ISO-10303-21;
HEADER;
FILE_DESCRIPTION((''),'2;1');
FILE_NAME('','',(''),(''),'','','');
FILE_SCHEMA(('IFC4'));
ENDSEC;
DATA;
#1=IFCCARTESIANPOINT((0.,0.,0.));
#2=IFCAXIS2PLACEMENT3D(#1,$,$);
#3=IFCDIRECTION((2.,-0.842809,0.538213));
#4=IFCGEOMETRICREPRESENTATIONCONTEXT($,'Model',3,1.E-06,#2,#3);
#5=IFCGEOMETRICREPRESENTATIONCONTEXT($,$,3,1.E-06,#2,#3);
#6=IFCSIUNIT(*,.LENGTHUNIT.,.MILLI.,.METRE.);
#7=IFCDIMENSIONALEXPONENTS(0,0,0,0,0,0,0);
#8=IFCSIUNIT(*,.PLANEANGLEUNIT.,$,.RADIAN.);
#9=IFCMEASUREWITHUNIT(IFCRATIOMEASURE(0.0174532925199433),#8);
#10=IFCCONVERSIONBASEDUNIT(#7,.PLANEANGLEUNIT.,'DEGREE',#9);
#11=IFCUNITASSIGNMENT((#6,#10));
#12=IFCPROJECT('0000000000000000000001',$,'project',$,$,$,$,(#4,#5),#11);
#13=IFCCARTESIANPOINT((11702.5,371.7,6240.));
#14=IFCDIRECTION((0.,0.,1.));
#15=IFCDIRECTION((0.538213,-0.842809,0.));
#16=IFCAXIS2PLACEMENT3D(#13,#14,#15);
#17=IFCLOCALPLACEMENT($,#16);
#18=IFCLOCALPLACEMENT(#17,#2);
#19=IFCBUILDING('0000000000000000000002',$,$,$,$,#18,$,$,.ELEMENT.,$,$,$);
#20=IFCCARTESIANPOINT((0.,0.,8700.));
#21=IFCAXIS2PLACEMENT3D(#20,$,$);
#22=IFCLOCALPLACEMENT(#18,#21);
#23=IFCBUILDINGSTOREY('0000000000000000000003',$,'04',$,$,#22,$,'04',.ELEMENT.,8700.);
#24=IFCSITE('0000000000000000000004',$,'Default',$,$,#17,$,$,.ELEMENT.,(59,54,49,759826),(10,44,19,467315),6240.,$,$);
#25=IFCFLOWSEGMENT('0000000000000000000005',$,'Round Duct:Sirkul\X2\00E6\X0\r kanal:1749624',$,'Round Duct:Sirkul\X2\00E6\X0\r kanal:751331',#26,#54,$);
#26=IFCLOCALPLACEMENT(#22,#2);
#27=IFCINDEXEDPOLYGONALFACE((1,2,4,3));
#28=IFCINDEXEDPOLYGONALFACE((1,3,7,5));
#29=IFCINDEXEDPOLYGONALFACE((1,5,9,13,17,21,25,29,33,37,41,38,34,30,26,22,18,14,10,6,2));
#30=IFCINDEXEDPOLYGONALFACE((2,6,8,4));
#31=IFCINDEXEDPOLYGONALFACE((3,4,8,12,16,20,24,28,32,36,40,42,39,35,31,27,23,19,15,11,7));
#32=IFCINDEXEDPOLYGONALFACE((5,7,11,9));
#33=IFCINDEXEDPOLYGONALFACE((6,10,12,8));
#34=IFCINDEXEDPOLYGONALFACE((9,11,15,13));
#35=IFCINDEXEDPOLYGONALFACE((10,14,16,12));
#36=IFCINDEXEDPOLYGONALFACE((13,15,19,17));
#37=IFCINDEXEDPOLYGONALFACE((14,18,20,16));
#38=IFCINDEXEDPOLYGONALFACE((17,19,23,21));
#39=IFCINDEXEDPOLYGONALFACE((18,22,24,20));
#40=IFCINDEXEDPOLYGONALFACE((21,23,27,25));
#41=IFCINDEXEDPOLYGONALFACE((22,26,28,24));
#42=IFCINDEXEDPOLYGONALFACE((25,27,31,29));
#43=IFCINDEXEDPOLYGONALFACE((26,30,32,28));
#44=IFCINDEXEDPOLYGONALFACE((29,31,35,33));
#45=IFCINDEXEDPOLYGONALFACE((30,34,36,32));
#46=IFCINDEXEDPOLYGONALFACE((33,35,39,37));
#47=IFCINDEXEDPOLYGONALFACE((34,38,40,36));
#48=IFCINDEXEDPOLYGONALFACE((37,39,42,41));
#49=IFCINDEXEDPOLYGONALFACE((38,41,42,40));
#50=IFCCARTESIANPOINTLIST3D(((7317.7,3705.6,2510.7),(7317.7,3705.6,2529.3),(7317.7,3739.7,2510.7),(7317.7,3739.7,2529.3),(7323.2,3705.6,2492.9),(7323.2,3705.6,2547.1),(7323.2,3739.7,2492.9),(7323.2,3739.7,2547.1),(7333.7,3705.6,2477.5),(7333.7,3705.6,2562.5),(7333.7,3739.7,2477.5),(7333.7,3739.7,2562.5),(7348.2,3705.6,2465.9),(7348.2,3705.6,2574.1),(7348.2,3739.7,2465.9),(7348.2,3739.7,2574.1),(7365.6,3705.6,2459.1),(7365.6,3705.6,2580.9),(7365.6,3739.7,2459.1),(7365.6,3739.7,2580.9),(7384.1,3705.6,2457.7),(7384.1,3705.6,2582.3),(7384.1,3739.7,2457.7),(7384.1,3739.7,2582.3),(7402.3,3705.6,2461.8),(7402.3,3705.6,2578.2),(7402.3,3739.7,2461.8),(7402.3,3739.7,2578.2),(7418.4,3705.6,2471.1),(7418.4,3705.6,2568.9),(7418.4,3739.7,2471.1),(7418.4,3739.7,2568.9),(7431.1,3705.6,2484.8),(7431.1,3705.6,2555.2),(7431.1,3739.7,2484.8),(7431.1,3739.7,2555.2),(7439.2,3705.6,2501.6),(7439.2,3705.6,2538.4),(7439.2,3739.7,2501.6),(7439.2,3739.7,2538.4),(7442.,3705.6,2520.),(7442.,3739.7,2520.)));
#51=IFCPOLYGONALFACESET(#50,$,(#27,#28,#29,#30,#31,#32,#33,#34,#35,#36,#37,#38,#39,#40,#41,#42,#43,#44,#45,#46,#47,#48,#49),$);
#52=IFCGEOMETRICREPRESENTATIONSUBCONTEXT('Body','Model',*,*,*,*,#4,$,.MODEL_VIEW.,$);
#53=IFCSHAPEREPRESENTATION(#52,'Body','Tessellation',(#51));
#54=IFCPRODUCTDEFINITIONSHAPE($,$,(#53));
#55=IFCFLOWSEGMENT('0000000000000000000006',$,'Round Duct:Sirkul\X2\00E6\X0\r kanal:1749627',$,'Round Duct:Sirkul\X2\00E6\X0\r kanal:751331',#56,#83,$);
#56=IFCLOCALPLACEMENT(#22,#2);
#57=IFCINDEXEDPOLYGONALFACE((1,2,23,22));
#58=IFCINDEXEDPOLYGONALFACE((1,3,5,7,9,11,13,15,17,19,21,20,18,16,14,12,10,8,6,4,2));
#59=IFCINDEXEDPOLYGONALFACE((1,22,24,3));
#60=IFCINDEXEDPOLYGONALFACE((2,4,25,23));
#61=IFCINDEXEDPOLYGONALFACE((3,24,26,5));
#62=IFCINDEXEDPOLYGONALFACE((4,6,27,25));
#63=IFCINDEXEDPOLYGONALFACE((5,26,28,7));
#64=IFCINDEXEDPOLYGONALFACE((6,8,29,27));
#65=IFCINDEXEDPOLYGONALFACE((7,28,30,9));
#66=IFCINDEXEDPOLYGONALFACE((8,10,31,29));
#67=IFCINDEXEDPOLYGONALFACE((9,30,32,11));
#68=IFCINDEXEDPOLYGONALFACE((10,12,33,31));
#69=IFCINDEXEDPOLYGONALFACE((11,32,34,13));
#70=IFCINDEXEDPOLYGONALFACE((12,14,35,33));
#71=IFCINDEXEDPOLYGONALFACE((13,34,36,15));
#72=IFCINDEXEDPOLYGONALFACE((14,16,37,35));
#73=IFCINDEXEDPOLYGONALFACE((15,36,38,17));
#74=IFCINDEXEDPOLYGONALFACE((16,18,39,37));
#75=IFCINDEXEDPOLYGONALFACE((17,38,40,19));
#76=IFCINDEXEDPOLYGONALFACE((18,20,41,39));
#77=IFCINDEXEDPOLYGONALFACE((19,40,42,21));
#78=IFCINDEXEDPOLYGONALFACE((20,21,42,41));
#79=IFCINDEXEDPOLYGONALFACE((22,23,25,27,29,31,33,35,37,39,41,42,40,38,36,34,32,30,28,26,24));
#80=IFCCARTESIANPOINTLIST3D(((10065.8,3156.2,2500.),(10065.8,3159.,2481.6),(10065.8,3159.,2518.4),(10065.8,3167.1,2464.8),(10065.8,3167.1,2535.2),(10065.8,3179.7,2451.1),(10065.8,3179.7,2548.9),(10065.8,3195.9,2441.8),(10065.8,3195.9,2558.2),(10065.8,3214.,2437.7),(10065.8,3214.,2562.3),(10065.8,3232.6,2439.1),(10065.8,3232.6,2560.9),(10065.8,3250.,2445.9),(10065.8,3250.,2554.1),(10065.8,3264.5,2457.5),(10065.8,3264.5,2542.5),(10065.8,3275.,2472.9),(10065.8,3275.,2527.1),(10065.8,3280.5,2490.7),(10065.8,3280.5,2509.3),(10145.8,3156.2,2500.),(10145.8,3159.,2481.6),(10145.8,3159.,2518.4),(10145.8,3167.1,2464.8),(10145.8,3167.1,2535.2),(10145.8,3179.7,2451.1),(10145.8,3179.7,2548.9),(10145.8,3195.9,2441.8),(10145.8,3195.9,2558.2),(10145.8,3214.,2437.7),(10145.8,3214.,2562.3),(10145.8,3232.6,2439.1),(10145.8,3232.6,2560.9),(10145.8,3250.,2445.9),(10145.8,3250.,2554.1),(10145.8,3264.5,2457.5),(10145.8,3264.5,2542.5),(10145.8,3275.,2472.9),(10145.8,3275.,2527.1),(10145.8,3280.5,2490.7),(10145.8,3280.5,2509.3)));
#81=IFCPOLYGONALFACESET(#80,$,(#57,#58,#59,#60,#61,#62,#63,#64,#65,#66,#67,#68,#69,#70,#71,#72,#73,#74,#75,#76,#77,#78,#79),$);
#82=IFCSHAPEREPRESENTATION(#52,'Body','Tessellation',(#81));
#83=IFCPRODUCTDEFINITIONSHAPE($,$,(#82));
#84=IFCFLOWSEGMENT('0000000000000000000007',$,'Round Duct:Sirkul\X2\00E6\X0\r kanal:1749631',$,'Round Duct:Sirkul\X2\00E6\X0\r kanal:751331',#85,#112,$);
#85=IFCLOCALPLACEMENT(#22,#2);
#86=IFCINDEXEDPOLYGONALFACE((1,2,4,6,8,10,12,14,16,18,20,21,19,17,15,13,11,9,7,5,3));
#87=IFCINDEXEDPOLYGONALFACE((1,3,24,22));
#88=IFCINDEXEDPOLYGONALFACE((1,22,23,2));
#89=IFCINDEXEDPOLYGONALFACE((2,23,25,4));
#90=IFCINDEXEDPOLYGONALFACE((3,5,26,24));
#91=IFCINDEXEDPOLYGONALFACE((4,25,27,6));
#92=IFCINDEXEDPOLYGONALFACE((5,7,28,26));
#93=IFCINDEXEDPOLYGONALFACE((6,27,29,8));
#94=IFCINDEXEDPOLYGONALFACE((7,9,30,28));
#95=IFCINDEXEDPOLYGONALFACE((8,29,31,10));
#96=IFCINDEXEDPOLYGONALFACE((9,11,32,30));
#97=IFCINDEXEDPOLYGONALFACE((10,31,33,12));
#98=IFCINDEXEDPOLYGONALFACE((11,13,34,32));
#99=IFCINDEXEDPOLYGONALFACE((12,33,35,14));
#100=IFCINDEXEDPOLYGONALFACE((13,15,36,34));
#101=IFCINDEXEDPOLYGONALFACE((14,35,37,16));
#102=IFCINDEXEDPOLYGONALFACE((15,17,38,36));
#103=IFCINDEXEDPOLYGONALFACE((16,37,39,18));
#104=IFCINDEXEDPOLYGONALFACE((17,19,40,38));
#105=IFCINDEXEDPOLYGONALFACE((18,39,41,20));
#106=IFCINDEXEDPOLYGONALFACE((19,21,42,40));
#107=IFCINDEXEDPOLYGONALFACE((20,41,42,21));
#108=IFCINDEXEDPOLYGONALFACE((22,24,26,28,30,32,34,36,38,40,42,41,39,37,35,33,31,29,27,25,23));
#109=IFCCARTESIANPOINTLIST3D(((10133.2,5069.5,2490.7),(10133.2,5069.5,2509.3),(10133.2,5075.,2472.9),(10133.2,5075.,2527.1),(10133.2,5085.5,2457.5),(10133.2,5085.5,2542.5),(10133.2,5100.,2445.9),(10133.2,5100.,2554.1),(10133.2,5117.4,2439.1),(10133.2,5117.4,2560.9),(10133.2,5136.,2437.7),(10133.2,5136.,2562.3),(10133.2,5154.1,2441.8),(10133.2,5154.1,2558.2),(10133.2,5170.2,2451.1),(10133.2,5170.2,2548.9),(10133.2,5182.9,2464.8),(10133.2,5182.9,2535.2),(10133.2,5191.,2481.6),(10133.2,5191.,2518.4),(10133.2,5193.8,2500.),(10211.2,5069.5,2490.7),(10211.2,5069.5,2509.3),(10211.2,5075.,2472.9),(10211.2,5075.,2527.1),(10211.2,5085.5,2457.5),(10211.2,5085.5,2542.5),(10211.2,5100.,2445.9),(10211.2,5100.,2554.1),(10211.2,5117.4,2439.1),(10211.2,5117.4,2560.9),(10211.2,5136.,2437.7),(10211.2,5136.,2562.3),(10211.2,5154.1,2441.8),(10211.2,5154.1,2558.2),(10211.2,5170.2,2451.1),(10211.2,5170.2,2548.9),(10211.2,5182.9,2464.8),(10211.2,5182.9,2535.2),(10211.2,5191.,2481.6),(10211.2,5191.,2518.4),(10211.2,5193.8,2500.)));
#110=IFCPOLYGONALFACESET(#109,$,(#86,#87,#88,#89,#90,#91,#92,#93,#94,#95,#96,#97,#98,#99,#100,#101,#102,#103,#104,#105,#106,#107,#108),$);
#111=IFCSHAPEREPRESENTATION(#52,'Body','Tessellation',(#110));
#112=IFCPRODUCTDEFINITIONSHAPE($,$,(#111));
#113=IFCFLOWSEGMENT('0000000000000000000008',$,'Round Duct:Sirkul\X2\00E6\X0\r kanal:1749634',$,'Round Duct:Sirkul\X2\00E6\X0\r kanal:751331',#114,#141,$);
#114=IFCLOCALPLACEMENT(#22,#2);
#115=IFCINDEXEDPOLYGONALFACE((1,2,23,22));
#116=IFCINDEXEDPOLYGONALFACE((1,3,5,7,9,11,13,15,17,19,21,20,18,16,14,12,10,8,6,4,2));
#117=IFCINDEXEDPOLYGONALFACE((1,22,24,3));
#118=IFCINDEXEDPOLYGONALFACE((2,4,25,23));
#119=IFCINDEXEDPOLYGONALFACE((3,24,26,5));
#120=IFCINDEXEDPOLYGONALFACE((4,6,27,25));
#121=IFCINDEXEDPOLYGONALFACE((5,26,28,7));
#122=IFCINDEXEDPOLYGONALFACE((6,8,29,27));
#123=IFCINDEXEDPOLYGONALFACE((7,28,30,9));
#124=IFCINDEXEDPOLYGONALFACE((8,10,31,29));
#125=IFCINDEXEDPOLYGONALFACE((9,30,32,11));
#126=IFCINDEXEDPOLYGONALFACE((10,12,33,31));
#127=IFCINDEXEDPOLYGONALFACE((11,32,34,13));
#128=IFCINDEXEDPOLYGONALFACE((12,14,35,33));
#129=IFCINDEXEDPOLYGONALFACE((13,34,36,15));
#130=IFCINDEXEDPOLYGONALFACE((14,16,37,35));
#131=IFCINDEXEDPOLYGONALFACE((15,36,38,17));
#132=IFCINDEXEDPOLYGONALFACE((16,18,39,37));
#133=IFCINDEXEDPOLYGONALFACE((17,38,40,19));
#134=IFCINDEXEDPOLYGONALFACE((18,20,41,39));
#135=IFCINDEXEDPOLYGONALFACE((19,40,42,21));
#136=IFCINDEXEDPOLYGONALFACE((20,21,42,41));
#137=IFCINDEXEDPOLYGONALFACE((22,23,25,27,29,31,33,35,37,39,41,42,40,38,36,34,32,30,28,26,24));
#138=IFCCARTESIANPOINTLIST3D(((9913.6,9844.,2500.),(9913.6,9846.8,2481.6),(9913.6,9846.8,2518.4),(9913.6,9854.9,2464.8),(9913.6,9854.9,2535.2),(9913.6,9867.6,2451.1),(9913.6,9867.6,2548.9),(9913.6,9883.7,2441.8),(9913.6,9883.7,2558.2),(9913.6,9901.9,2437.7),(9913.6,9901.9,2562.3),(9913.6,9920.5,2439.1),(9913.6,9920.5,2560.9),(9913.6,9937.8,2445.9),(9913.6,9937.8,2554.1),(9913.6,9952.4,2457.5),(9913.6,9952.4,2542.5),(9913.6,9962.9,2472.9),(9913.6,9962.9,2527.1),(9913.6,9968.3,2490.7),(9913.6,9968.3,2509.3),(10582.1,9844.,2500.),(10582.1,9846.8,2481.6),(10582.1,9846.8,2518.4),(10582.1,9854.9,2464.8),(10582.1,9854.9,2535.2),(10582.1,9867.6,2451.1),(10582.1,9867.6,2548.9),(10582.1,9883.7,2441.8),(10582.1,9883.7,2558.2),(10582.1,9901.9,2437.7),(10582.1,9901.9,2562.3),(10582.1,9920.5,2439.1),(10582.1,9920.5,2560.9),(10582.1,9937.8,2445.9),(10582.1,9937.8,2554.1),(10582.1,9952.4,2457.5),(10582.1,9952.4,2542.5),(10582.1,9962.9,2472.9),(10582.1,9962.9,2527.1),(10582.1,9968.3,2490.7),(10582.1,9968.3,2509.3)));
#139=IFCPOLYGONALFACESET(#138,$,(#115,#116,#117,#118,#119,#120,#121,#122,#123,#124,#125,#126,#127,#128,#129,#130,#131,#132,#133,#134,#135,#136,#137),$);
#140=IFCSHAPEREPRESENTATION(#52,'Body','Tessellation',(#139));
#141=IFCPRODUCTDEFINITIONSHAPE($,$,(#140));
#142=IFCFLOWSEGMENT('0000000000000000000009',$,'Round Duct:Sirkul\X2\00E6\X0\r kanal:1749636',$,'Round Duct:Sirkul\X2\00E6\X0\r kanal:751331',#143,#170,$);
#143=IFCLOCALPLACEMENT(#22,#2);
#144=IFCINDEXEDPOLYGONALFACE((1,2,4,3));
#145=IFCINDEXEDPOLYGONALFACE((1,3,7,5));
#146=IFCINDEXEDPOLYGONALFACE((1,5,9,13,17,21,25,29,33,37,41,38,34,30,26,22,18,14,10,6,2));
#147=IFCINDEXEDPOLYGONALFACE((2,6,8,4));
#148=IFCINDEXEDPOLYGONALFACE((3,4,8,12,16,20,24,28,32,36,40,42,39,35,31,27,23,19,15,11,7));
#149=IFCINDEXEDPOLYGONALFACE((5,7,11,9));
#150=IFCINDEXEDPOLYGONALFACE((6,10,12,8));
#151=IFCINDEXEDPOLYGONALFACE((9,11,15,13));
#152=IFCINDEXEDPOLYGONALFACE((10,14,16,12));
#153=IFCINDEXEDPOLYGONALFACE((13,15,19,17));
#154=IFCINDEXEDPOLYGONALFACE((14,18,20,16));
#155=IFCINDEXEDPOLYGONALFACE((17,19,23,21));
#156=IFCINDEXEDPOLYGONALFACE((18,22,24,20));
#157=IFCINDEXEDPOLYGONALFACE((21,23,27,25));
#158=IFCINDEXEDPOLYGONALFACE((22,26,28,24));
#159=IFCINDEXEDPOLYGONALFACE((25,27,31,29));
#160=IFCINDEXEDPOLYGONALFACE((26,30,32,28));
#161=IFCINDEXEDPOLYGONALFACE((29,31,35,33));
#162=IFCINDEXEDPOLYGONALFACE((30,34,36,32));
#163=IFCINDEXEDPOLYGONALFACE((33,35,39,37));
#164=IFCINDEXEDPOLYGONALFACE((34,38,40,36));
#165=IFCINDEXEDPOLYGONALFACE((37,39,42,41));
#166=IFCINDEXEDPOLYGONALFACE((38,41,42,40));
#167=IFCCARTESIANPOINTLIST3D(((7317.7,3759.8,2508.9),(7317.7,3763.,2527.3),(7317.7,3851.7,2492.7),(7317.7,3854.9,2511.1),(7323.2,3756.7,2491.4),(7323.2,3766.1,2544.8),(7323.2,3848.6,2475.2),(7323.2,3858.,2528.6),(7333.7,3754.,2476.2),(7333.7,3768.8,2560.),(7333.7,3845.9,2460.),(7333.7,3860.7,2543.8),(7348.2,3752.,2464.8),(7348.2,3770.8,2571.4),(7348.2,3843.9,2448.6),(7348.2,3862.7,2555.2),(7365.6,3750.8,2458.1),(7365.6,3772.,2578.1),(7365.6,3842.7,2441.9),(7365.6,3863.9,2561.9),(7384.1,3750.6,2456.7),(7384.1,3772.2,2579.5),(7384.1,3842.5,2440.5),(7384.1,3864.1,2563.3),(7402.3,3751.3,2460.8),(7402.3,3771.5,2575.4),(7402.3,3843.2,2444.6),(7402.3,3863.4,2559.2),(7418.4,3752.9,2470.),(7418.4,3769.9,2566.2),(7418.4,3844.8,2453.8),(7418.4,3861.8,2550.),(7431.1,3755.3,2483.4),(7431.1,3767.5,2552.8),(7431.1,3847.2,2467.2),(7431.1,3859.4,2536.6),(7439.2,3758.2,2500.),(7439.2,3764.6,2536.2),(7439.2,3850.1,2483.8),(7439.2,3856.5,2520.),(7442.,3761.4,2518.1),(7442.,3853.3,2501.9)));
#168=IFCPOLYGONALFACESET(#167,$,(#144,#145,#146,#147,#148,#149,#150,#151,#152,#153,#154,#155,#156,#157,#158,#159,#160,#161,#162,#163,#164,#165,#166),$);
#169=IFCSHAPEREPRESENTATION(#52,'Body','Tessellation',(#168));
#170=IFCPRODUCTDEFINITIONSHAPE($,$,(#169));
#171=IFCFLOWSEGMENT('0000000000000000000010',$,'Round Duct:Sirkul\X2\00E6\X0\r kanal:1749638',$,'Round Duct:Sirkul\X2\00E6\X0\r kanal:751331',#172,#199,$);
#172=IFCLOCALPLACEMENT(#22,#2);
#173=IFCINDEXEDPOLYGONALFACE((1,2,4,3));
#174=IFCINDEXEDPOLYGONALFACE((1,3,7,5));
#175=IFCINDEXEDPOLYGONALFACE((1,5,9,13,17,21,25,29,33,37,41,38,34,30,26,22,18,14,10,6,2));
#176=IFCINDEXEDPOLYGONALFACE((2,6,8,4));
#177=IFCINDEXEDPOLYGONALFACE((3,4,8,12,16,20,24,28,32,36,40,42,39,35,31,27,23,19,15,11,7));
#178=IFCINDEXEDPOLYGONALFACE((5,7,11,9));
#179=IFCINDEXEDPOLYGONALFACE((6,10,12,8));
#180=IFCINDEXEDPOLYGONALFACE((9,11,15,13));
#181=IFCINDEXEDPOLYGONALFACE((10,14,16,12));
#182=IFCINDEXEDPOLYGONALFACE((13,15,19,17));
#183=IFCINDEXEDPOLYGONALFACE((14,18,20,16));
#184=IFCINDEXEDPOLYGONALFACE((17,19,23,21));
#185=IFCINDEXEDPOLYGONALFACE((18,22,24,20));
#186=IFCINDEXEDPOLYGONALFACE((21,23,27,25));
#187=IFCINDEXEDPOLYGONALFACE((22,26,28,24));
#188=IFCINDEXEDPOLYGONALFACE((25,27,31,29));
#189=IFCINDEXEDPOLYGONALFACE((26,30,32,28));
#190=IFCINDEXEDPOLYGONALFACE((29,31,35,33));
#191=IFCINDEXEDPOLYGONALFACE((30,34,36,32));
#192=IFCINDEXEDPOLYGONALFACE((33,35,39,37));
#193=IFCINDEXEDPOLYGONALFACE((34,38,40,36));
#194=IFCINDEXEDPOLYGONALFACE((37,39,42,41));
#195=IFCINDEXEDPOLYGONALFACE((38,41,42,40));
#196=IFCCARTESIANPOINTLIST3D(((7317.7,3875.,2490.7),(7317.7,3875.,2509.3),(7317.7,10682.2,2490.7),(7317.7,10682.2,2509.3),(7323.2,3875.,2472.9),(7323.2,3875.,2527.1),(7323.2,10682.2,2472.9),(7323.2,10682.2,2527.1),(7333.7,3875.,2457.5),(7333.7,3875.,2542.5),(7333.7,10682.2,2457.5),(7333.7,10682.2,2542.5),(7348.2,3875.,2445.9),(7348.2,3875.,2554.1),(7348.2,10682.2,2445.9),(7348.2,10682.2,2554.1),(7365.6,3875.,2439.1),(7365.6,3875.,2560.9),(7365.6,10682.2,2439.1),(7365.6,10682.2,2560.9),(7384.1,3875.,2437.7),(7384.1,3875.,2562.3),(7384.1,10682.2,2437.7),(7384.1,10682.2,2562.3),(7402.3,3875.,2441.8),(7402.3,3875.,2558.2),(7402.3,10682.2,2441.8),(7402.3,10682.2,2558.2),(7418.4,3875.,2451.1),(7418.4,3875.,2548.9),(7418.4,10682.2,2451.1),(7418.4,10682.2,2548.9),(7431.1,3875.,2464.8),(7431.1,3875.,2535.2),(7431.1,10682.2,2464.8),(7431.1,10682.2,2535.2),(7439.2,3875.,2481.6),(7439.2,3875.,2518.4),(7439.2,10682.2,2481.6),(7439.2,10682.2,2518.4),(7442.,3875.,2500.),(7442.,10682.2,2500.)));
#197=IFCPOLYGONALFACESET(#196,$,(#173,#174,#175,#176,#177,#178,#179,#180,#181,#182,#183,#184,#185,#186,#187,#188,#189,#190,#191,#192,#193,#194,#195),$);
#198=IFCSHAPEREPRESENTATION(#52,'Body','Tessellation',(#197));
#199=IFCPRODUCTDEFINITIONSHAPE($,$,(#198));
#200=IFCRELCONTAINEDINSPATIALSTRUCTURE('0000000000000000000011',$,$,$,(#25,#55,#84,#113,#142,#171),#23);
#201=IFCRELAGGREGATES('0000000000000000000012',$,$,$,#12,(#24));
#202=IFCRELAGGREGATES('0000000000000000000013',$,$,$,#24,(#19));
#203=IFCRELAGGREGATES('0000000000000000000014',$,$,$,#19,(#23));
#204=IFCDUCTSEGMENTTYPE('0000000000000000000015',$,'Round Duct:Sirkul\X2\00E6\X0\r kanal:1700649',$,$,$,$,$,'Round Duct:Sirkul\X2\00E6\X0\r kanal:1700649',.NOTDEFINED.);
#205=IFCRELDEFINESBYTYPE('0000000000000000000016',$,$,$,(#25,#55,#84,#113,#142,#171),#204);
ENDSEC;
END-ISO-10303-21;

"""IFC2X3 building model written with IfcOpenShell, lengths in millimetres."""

from ifc_helpers import new_model, entity, si_unit, converted_unit, direction, frame, frame_2d, origin, origin_2d_with_axis, place, context, subcontext, project, spatial, circle, extrude, type_object, element, save


model = new_model("IFC2X3")

# Units and contexts
model_context = context("Model", 3, precision=1e-06, world=origin(), true_north=direction((2.0, -0.842809, 0.538213)))
context_of_model = context(None, 3, precision=1e-06, world=origin(), true_north=direction((2.0, -0.842809, 0.538213)))
body_context = subcontext(model_context, "Body", "Model", "MODEL_VIEW")
ifc_project = project(units=[si_unit("LENGTHUNIT", "METRE", prefix="MILLI"), converted_unit("PLANEANGLEUNIT", "DEGREE", entity("IfcRatioMeasure", 0.0174532925199433), si_unit("PLANEANGLEUNIT", "RADIAN"), dimensions=[0, 0, 0, 0, 0, 0, 0])], contexts=[model_context, context_of_model])

# Site, building, storey
site_placement = place(None, frame((11702.5, 371.7, 6240.0), z_axis=(0.0, 0.0, 1.0), x_axis=(0.538213, -0.842809, 0.0)))
site = spatial("IfcSite", under=ifc_project, at=site_placement, Name="Default", CompositionType="ELEMENT", RefLatitude=(59, 54, 49, 759826), RefLongitude=(10, 44, 19, 467315), RefElevation=6240.0)
building_placement = place(site_placement, origin())
building = spatial("IfcBuilding", under=site, at=building_placement, CompositionType="ELEMENT")
storey_placement = place(building_placement, frame((0.0, 0.0, 8700.0)))
storey = spatial("IfcBuildingStorey", under=building, at=storey_placement, Name="04", LongName="04", CompositionType="ELEMENT", Elevation=8700.0)

# Flow segments
duct_segment_type = type_object("IfcDuctSegmentType", Name="Round Duct:Sirkulær kanal:1700649", ElementType="Round Duct:Sirkulær kanal:1700649", PredefinedType="NOTDEFINED")
flow_segment_1_placement = place(storey_placement, origin())
element("IfcFlowSegment", 1, at=flow_segment_1_placement, inside=storey, type_object=duct_segment_type, Name="Round Duct:Sirkulær kanal:1749624", ObjectType="Round Duct:Sirkulær kanal:751331", context=body_context, shape_type="SweptSolid", body=[
    extrude(circle(Radius=62.5, at=origin_2d_with_axis()), frame((7379.5, 3705.6, 2520.0), z_axis=(0.0, 1.0, 0.0), x_axis=(1.0, 0.0, 0.0)), (0.0, 0.0, 1.0), 34.1),
])
flow_segment_2_placement = place(storey_placement, origin())
element("IfcFlowSegment", 2, at=flow_segment_2_placement, inside=storey, type_object=duct_segment_type, Name="Round Duct:Sirkulær kanal:1749627", ObjectType="Round Duct:Sirkulær kanal:751331", context=body_context, shape_type="SweptSolid", body=[
    extrude(circle(Radius=62.5, at=frame_2d((0.0, 0.0), x_axis=(1.0, 0.0))), frame((10065.8, 3218.7, 2500.0), z_axis=(1.0, 0.0, 0.0), x_axis=(0.0, -1.0, 0.0)), (0.0, 0.0, 1.0), 80.0),
])
flow_segment_3_placement = place(storey_placement, origin())
element("IfcFlowSegment", 3, at=flow_segment_3_placement, inside=storey, type_object=duct_segment_type, Name="Round Duct:Sirkulær kanal:1749631", ObjectType="Round Duct:Sirkulær kanal:751331", context=body_context, shape_type="SweptSolid", body=[
    extrude(circle(Radius=62.5, at=origin_2d_with_axis()), frame((10133.2, 5131.3, 2500.0), z_axis=(1.0, 0.0, 0.0), x_axis=(0.0, 1.0, 0.0)), (0.0, 0.0, 1.0), 78.0),
])
flow_segment_4_placement = place(storey_placement, origin())
element("IfcFlowSegment", 4, at=flow_segment_4_placement, inside=storey, type_object=duct_segment_type, Name="Round Duct:Sirkulær kanal:1749634", ObjectType="Round Duct:Sirkulær kanal:751331", context=body_context, shape_type="SweptSolid", body=[
    extrude(circle(Radius=62.5, at=origin_2d_with_axis()), frame((9913.6, 9906.5, 2500.0), z_axis=(1.0, 0.0, 0.0), x_axis=(0.0, -1.0, 0.0)), (0.0, 0.0, 1.0), 668.5),
])
flow_segment_5_placement = place(storey_placement, origin())
element("IfcFlowSegment", 5, at=flow_segment_5_placement, inside=storey, type_object=duct_segment_type, Name="Round Duct:Sirkulær kanal:1749636", ObjectType="Round Duct:Sirkulær kanal:751331", context=body_context, shape_type="SweptSolid", body=[
    extrude(circle(Radius=62.5, at=origin_2d_with_axis()), frame((7379.5, 3761.4, 2518.1), z_axis=(0.0, 0.984808, -0.173648), x_axis=(1.0, 0.0, 0.0)), (0.0, 0.0, 1.0), 93.3),
])
flow_segment_6_placement = place(storey_placement, origin())
element("IfcFlowSegment", 6, at=flow_segment_6_placement, inside=storey, type_object=duct_segment_type, Name="Round Duct:Sirkulær kanal:1749638", ObjectType="Round Duct:Sirkulær kanal:751331", context=body_context, shape_type="SweptSolid", body=[
    extrude(circle(Radius=62.5, at=origin_2d_with_axis()), frame((7379.5, 3875.0, 2500.0), z_axis=(0.0, 1.0, 0.0), x_axis=(1.0, 0.0, 0.0)), (0.0, 0.0, 1.0), 6807.2),
])

save(model, "model.ifc")
